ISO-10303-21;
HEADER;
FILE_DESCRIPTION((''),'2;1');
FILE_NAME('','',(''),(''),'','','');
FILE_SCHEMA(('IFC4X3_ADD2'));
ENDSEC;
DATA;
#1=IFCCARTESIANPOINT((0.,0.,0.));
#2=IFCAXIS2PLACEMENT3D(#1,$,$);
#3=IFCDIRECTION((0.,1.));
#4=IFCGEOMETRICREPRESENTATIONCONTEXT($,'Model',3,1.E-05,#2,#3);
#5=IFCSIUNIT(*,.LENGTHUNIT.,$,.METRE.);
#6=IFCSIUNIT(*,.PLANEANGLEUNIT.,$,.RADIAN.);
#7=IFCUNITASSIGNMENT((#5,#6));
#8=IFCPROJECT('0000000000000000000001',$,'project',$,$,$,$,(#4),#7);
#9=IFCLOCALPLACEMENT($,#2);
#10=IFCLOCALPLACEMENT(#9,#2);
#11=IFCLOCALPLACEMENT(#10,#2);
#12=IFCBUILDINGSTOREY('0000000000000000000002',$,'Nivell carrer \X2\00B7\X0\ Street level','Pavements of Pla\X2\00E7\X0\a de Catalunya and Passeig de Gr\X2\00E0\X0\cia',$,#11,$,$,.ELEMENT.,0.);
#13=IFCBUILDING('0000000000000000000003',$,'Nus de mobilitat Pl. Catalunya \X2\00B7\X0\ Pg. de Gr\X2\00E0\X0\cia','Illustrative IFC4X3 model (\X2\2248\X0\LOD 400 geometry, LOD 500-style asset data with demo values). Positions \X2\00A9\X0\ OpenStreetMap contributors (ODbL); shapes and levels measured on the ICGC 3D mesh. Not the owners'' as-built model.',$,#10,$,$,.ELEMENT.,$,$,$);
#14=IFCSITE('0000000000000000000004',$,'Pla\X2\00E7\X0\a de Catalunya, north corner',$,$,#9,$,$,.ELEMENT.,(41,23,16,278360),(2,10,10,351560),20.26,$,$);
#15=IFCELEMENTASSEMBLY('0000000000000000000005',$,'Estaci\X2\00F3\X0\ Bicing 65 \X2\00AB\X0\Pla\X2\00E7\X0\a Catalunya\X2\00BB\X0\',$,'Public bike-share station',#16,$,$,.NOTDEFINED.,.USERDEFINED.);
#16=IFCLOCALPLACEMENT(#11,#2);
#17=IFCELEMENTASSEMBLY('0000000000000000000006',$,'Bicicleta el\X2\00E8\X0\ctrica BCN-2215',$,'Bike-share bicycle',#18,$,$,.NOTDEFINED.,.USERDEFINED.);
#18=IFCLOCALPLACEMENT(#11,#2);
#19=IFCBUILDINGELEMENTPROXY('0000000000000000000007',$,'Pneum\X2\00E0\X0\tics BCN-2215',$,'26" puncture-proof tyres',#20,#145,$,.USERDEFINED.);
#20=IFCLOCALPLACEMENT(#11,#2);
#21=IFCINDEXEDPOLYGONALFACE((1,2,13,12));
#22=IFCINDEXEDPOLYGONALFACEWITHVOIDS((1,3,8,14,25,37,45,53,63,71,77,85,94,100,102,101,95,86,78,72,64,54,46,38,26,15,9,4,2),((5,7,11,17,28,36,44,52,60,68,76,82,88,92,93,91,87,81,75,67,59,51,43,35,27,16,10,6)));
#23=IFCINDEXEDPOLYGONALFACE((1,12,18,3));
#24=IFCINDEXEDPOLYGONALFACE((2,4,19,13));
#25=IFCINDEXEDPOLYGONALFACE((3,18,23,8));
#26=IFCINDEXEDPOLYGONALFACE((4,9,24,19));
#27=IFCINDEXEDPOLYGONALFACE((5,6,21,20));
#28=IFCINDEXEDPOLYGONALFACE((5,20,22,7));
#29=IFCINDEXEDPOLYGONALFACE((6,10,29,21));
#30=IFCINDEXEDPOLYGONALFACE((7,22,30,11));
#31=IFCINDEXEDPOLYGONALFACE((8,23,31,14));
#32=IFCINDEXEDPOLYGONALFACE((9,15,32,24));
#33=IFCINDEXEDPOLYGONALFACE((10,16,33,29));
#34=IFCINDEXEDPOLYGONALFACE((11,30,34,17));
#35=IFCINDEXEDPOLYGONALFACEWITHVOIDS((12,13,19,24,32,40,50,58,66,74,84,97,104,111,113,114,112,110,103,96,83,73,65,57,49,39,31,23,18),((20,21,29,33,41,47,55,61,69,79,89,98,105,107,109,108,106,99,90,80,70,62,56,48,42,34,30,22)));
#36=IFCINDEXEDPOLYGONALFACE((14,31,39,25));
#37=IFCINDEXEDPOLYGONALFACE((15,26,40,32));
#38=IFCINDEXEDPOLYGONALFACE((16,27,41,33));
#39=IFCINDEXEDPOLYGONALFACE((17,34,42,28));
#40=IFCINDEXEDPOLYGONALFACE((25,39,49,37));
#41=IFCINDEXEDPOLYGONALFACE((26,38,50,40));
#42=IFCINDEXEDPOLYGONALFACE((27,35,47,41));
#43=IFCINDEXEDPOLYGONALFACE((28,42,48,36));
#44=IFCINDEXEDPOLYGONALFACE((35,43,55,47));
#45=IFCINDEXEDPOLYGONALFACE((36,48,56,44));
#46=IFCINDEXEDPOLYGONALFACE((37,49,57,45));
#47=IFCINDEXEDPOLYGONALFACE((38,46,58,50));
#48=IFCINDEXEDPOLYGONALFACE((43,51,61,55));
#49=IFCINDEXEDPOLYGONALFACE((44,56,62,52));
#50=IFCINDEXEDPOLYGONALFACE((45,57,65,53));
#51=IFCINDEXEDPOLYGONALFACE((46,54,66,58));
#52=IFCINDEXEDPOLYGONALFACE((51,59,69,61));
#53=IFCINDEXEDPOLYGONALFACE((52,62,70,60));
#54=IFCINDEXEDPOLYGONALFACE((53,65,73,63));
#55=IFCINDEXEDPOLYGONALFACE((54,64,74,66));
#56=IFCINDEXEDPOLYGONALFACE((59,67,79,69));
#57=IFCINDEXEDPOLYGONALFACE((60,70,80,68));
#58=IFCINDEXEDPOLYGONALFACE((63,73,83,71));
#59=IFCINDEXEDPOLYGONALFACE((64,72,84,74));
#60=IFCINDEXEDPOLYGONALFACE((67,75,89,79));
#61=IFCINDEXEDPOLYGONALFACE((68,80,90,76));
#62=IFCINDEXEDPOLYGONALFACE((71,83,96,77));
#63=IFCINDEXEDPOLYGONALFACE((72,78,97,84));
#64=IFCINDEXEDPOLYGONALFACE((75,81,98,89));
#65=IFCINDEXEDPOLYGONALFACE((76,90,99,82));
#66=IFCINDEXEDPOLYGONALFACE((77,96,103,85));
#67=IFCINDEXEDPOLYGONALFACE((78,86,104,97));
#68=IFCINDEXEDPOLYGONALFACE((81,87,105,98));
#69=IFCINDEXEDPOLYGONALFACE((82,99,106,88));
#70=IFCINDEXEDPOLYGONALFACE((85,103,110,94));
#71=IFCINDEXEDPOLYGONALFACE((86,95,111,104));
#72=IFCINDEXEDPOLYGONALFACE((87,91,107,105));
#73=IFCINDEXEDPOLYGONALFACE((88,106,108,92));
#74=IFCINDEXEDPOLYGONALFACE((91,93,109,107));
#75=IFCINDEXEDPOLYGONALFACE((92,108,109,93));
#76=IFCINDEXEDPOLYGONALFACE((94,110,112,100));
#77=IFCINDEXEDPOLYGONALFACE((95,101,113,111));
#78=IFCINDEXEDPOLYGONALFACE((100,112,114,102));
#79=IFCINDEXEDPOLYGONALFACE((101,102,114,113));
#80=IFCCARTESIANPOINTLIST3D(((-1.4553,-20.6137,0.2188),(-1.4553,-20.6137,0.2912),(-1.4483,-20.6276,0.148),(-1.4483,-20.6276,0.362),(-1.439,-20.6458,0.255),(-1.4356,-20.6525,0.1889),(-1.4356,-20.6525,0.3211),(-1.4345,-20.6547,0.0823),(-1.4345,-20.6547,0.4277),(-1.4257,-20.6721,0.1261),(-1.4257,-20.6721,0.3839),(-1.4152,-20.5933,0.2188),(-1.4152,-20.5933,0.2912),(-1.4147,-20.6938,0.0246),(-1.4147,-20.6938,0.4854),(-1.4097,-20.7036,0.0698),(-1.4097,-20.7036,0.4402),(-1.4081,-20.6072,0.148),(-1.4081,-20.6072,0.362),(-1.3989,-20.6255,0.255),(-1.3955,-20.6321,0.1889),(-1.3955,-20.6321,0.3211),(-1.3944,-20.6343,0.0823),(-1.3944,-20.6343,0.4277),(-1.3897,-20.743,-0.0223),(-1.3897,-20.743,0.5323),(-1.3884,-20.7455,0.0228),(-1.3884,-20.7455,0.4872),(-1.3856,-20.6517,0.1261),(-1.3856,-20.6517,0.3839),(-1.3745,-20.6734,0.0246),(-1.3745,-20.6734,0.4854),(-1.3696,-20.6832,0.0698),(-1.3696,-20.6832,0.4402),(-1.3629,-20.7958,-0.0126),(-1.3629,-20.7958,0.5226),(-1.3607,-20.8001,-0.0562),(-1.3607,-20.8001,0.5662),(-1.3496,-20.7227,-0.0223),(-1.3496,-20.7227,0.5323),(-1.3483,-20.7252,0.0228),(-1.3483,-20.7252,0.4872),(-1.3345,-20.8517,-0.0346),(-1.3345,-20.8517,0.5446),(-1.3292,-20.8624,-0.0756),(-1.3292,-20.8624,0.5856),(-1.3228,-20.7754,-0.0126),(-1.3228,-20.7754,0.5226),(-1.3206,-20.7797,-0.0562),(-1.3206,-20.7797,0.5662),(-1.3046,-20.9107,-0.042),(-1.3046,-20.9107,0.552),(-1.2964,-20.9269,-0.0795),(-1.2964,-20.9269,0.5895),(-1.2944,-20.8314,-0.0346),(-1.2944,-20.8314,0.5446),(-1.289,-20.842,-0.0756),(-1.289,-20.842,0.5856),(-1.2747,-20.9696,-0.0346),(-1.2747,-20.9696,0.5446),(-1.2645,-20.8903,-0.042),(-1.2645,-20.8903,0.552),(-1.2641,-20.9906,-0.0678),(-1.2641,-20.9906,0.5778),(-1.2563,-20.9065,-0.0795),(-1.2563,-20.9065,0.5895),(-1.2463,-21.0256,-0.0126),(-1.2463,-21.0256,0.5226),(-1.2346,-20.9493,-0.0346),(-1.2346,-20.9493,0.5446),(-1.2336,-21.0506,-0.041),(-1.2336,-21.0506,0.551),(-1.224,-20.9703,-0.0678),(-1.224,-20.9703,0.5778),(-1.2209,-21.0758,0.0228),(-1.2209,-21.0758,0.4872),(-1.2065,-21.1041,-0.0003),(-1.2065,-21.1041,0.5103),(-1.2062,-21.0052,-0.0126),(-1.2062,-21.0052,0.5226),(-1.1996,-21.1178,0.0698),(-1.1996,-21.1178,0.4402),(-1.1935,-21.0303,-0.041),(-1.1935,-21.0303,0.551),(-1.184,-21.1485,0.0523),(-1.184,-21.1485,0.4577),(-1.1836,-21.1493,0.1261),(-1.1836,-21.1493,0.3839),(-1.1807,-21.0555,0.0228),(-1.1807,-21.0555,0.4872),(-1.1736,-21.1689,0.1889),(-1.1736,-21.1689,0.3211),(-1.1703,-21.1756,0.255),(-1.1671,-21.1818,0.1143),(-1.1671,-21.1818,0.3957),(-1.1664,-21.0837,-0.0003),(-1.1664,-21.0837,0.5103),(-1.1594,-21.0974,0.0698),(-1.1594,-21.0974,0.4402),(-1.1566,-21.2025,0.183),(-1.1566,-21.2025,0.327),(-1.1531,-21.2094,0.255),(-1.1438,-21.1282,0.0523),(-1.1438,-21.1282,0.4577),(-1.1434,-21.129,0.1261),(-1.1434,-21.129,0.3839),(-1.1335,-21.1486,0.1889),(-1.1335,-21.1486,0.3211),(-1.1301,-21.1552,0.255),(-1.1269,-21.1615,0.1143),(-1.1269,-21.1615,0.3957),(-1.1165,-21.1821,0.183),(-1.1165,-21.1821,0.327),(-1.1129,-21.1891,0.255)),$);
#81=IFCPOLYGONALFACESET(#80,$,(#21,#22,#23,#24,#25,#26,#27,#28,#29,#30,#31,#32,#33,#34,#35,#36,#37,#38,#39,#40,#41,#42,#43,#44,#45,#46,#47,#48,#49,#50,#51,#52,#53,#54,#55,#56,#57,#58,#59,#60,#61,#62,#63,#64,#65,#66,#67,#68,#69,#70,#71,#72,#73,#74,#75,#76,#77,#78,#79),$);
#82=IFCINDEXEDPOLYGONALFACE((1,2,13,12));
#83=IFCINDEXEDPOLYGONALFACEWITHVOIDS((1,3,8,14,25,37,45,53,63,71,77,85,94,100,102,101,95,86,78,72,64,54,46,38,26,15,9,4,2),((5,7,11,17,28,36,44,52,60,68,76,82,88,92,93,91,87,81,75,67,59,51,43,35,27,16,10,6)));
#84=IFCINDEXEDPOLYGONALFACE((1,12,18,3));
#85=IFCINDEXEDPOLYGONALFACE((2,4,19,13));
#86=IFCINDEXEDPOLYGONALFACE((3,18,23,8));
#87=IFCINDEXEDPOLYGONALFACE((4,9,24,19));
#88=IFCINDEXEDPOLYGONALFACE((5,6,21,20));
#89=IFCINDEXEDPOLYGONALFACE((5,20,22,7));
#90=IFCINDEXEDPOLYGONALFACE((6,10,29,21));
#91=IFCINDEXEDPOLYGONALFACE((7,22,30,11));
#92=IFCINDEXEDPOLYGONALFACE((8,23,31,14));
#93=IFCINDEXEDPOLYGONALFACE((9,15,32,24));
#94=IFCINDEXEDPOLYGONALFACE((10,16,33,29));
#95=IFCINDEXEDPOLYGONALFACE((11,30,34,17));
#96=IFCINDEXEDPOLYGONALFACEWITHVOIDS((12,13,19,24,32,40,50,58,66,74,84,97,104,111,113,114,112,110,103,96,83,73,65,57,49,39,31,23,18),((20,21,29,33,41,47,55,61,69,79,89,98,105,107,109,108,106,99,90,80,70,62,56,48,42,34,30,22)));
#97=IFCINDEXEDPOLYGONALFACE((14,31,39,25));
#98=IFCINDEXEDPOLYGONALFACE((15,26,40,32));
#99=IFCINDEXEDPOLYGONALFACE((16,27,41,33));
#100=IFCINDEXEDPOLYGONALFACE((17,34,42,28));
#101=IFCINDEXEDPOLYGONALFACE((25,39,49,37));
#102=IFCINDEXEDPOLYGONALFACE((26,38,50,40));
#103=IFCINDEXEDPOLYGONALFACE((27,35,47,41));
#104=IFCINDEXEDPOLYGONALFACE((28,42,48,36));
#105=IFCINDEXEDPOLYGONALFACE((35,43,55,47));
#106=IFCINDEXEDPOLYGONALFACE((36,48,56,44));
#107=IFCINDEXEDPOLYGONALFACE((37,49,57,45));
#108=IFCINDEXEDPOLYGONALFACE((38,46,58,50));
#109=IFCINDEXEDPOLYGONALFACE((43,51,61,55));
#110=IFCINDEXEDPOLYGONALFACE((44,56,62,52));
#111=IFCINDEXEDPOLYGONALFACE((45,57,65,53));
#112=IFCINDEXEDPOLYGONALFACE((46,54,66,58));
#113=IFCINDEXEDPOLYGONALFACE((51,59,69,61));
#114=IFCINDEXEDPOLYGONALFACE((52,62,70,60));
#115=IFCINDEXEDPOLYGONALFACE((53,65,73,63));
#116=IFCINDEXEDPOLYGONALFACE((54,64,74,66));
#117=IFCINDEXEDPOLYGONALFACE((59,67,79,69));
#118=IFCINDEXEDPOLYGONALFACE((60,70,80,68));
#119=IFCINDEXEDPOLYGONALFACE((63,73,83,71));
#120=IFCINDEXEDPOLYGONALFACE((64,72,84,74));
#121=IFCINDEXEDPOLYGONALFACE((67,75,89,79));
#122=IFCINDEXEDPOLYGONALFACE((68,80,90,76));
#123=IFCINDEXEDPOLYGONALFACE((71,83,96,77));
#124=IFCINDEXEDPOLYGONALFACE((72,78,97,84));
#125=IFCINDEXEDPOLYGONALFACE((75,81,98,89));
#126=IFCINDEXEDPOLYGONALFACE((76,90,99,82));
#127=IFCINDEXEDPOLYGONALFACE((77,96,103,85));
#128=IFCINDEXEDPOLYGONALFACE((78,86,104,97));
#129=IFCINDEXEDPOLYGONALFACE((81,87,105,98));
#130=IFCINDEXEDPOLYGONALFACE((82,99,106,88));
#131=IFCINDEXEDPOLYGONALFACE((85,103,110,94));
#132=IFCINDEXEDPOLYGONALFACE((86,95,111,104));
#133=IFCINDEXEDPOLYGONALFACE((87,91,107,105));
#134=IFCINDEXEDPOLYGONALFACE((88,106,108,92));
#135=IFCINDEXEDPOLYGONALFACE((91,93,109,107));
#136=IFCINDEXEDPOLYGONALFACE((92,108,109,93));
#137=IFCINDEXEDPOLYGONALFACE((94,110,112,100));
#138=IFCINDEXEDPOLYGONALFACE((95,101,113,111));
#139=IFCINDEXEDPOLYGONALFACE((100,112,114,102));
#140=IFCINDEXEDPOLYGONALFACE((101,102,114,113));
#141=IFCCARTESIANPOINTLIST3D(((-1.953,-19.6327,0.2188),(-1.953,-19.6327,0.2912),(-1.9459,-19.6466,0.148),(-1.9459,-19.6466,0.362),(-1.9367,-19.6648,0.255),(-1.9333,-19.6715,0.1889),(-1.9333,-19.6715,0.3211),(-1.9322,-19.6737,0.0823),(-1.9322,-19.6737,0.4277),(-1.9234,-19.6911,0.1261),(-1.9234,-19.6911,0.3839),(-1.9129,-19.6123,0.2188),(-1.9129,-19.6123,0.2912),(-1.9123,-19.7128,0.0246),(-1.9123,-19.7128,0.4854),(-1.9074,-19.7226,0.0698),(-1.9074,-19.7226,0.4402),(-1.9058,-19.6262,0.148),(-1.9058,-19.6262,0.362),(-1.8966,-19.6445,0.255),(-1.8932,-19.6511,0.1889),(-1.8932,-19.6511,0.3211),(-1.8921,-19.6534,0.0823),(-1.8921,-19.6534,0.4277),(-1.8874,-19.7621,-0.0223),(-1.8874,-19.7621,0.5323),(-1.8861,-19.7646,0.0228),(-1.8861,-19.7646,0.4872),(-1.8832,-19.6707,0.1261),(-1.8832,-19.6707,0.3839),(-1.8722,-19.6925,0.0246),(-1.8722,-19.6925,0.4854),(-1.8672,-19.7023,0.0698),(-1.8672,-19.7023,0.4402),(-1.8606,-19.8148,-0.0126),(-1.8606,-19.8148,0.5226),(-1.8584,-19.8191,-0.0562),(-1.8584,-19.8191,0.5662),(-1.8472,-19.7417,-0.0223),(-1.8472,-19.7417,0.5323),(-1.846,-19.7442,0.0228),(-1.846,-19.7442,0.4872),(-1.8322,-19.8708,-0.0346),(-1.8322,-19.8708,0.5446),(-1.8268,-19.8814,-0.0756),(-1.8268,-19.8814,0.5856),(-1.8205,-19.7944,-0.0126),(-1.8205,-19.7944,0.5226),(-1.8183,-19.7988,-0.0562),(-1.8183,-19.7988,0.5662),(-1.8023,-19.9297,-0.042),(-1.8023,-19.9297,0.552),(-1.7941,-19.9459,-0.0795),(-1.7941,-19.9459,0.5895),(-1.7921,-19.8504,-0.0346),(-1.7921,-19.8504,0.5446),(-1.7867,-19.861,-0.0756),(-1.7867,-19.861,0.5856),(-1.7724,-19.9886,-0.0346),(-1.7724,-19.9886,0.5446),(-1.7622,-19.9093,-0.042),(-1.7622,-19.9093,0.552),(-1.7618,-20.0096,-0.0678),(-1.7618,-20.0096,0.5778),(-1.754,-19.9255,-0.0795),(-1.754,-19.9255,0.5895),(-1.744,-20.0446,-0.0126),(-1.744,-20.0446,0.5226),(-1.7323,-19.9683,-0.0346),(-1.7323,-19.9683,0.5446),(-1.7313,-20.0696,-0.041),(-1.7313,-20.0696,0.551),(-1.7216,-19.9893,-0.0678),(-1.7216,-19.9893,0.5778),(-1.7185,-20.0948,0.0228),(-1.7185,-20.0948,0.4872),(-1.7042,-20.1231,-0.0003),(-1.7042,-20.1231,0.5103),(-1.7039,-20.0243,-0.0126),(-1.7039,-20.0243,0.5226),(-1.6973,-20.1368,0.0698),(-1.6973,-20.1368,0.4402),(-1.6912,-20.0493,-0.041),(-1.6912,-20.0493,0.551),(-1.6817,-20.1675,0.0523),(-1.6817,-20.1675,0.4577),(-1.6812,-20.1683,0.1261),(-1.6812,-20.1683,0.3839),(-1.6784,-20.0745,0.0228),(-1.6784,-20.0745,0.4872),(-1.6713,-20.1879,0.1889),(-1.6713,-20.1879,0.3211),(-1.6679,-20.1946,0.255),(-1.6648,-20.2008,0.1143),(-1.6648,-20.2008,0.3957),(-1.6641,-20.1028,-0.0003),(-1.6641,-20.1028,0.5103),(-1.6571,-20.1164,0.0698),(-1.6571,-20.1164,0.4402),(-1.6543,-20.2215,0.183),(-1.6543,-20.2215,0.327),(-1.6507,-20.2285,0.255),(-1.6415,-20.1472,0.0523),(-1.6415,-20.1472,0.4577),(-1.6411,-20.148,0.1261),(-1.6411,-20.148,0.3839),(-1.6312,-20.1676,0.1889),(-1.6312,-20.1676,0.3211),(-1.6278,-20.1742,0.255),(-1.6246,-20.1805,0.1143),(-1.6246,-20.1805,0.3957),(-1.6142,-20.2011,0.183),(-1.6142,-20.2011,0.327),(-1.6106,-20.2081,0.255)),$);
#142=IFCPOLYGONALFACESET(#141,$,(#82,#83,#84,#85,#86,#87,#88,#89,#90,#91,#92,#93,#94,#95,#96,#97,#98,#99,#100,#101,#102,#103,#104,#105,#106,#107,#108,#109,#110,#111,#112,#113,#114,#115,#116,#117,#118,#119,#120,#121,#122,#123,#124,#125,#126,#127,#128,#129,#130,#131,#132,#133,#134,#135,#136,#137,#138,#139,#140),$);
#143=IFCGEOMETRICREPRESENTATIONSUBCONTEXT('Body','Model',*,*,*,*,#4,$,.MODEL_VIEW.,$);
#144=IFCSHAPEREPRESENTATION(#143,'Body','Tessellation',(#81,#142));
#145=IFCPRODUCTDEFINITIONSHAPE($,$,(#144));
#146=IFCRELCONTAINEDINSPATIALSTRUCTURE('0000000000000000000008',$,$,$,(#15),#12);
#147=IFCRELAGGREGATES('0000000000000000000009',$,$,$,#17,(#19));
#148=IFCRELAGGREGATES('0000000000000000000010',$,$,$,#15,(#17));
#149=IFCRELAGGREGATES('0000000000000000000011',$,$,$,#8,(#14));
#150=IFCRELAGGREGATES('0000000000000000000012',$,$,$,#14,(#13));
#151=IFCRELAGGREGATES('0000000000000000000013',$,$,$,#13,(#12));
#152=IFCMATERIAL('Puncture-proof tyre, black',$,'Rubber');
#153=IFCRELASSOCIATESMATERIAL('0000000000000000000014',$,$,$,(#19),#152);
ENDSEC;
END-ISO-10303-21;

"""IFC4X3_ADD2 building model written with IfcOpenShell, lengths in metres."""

from ifc_helpers import new_model, si_unit, direction, frame, origin, origin_2d_with_axis, place, context, subcontext, project, spatial, hollow_circle, extrude, material, element, aggregate, save


model = new_model("IFC4X3_ADD2")

# Units and contexts
model_context = context("Model", 3, precision=1e-05, world=origin(), true_north=direction((0.0, 1.0)))
body_context = subcontext(model_context, "Body", "Model", "MODEL_VIEW")
ifc_project = project(units=[si_unit("LENGTHUNIT", "METRE"), si_unit("PLANEANGLEUNIT", "RADIAN")], contexts=[model_context])

# Site, building, storey
site_placement = place(None, origin())
site = spatial("IfcSite", under=ifc_project, at=site_placement, Name="Plaça de Catalunya, north corner", CompositionType="ELEMENT", RefLatitude=(41, 23, 16, 278360), RefLongitude=(2, 10, 10, 351560), RefElevation=20.26)
building_placement = place(site_placement, origin())
building = spatial("IfcBuilding", under=site, at=building_placement, Name="Nus de mobilitat Pl. Catalunya · Pg. de Gràcia", Description="Illustrative IFC4X3 model (≈LOD 400 geometry, LOD 500-style asset data with demo values). Positions © OpenStreetMap contributors (ODbL); shapes and levels measured on the ICGC 3D mesh. Not the owners' as-built model.", CompositionType="ELEMENT")
storey_placement = place(building_placement, origin())
storey = spatial("IfcBuildingStorey", under=building, at=storey_placement, Name="Nivell carrer · Street level", Description="Pavements of Plaça de Catalunya and Passeig de Gràcia", CompositionType="ELEMENT", Elevation=0.0)

# Element assemblies, building element proxy
assembly_1_placement = place(building_placement, origin())
assembly_1 = element("IfcElementAssembly", 1, at=assembly_1_placement, inside=storey, Name="Estació Bicing 65 «Plaça Catalunya»", ObjectType="Public bike-share station", AssemblyPlace="NOTDEFINED", PredefinedType="USERDEFINED")
assembly_2_placement = place(building_placement, origin())
assembly_2 = element("IfcElementAssembly", 2, at=assembly_2_placement, Name="Bicicleta elèctrica BCN-2215", ObjectType="Bike-share bicycle", AssemblyPlace="NOTDEFINED", PredefinedType="USERDEFINED")
ifc_material_1 = material(Name="Puncture-proof tyre, black", Category="Rubber")
proxy_1_placement = place(building_placement, origin())
proxy_1 = element("IfcBuildingElementProxy", 3, at=proxy_1_placement, material=ifc_material_1, Name="Pneumàtics BCN-2215", ObjectType="26\" puncture-proof tyres", PredefinedType="USERDEFINED", context=body_context, shape_type="SweptSolid", body=[
    extrude(hollow_circle(Radius=0.335, WallThickness=0.038, at=origin_2d_with_axis()), frame((-1.3046, -20.9107, 0.255), z_axis=(0.891798, 0.452435, 0.0), x_axis=(0.452435, -0.891798, 0.0)), (0.0, 0.0, 1.0), 0.045),
    extrude(hollow_circle(Radius=0.335, WallThickness=0.038, at=origin_2d_with_axis()), frame((-1.8023, -19.9297, 0.255), z_axis=(0.891798, 0.452435, 0.0), x_axis=(0.452435, -0.891798, 0.0)), (0.0, 0.0, 1.0), 0.045),
])
aggregate(assembly_2, [proxy_1])
aggregate(assembly_1, [assembly_2])

save(model, "model.ifc")
